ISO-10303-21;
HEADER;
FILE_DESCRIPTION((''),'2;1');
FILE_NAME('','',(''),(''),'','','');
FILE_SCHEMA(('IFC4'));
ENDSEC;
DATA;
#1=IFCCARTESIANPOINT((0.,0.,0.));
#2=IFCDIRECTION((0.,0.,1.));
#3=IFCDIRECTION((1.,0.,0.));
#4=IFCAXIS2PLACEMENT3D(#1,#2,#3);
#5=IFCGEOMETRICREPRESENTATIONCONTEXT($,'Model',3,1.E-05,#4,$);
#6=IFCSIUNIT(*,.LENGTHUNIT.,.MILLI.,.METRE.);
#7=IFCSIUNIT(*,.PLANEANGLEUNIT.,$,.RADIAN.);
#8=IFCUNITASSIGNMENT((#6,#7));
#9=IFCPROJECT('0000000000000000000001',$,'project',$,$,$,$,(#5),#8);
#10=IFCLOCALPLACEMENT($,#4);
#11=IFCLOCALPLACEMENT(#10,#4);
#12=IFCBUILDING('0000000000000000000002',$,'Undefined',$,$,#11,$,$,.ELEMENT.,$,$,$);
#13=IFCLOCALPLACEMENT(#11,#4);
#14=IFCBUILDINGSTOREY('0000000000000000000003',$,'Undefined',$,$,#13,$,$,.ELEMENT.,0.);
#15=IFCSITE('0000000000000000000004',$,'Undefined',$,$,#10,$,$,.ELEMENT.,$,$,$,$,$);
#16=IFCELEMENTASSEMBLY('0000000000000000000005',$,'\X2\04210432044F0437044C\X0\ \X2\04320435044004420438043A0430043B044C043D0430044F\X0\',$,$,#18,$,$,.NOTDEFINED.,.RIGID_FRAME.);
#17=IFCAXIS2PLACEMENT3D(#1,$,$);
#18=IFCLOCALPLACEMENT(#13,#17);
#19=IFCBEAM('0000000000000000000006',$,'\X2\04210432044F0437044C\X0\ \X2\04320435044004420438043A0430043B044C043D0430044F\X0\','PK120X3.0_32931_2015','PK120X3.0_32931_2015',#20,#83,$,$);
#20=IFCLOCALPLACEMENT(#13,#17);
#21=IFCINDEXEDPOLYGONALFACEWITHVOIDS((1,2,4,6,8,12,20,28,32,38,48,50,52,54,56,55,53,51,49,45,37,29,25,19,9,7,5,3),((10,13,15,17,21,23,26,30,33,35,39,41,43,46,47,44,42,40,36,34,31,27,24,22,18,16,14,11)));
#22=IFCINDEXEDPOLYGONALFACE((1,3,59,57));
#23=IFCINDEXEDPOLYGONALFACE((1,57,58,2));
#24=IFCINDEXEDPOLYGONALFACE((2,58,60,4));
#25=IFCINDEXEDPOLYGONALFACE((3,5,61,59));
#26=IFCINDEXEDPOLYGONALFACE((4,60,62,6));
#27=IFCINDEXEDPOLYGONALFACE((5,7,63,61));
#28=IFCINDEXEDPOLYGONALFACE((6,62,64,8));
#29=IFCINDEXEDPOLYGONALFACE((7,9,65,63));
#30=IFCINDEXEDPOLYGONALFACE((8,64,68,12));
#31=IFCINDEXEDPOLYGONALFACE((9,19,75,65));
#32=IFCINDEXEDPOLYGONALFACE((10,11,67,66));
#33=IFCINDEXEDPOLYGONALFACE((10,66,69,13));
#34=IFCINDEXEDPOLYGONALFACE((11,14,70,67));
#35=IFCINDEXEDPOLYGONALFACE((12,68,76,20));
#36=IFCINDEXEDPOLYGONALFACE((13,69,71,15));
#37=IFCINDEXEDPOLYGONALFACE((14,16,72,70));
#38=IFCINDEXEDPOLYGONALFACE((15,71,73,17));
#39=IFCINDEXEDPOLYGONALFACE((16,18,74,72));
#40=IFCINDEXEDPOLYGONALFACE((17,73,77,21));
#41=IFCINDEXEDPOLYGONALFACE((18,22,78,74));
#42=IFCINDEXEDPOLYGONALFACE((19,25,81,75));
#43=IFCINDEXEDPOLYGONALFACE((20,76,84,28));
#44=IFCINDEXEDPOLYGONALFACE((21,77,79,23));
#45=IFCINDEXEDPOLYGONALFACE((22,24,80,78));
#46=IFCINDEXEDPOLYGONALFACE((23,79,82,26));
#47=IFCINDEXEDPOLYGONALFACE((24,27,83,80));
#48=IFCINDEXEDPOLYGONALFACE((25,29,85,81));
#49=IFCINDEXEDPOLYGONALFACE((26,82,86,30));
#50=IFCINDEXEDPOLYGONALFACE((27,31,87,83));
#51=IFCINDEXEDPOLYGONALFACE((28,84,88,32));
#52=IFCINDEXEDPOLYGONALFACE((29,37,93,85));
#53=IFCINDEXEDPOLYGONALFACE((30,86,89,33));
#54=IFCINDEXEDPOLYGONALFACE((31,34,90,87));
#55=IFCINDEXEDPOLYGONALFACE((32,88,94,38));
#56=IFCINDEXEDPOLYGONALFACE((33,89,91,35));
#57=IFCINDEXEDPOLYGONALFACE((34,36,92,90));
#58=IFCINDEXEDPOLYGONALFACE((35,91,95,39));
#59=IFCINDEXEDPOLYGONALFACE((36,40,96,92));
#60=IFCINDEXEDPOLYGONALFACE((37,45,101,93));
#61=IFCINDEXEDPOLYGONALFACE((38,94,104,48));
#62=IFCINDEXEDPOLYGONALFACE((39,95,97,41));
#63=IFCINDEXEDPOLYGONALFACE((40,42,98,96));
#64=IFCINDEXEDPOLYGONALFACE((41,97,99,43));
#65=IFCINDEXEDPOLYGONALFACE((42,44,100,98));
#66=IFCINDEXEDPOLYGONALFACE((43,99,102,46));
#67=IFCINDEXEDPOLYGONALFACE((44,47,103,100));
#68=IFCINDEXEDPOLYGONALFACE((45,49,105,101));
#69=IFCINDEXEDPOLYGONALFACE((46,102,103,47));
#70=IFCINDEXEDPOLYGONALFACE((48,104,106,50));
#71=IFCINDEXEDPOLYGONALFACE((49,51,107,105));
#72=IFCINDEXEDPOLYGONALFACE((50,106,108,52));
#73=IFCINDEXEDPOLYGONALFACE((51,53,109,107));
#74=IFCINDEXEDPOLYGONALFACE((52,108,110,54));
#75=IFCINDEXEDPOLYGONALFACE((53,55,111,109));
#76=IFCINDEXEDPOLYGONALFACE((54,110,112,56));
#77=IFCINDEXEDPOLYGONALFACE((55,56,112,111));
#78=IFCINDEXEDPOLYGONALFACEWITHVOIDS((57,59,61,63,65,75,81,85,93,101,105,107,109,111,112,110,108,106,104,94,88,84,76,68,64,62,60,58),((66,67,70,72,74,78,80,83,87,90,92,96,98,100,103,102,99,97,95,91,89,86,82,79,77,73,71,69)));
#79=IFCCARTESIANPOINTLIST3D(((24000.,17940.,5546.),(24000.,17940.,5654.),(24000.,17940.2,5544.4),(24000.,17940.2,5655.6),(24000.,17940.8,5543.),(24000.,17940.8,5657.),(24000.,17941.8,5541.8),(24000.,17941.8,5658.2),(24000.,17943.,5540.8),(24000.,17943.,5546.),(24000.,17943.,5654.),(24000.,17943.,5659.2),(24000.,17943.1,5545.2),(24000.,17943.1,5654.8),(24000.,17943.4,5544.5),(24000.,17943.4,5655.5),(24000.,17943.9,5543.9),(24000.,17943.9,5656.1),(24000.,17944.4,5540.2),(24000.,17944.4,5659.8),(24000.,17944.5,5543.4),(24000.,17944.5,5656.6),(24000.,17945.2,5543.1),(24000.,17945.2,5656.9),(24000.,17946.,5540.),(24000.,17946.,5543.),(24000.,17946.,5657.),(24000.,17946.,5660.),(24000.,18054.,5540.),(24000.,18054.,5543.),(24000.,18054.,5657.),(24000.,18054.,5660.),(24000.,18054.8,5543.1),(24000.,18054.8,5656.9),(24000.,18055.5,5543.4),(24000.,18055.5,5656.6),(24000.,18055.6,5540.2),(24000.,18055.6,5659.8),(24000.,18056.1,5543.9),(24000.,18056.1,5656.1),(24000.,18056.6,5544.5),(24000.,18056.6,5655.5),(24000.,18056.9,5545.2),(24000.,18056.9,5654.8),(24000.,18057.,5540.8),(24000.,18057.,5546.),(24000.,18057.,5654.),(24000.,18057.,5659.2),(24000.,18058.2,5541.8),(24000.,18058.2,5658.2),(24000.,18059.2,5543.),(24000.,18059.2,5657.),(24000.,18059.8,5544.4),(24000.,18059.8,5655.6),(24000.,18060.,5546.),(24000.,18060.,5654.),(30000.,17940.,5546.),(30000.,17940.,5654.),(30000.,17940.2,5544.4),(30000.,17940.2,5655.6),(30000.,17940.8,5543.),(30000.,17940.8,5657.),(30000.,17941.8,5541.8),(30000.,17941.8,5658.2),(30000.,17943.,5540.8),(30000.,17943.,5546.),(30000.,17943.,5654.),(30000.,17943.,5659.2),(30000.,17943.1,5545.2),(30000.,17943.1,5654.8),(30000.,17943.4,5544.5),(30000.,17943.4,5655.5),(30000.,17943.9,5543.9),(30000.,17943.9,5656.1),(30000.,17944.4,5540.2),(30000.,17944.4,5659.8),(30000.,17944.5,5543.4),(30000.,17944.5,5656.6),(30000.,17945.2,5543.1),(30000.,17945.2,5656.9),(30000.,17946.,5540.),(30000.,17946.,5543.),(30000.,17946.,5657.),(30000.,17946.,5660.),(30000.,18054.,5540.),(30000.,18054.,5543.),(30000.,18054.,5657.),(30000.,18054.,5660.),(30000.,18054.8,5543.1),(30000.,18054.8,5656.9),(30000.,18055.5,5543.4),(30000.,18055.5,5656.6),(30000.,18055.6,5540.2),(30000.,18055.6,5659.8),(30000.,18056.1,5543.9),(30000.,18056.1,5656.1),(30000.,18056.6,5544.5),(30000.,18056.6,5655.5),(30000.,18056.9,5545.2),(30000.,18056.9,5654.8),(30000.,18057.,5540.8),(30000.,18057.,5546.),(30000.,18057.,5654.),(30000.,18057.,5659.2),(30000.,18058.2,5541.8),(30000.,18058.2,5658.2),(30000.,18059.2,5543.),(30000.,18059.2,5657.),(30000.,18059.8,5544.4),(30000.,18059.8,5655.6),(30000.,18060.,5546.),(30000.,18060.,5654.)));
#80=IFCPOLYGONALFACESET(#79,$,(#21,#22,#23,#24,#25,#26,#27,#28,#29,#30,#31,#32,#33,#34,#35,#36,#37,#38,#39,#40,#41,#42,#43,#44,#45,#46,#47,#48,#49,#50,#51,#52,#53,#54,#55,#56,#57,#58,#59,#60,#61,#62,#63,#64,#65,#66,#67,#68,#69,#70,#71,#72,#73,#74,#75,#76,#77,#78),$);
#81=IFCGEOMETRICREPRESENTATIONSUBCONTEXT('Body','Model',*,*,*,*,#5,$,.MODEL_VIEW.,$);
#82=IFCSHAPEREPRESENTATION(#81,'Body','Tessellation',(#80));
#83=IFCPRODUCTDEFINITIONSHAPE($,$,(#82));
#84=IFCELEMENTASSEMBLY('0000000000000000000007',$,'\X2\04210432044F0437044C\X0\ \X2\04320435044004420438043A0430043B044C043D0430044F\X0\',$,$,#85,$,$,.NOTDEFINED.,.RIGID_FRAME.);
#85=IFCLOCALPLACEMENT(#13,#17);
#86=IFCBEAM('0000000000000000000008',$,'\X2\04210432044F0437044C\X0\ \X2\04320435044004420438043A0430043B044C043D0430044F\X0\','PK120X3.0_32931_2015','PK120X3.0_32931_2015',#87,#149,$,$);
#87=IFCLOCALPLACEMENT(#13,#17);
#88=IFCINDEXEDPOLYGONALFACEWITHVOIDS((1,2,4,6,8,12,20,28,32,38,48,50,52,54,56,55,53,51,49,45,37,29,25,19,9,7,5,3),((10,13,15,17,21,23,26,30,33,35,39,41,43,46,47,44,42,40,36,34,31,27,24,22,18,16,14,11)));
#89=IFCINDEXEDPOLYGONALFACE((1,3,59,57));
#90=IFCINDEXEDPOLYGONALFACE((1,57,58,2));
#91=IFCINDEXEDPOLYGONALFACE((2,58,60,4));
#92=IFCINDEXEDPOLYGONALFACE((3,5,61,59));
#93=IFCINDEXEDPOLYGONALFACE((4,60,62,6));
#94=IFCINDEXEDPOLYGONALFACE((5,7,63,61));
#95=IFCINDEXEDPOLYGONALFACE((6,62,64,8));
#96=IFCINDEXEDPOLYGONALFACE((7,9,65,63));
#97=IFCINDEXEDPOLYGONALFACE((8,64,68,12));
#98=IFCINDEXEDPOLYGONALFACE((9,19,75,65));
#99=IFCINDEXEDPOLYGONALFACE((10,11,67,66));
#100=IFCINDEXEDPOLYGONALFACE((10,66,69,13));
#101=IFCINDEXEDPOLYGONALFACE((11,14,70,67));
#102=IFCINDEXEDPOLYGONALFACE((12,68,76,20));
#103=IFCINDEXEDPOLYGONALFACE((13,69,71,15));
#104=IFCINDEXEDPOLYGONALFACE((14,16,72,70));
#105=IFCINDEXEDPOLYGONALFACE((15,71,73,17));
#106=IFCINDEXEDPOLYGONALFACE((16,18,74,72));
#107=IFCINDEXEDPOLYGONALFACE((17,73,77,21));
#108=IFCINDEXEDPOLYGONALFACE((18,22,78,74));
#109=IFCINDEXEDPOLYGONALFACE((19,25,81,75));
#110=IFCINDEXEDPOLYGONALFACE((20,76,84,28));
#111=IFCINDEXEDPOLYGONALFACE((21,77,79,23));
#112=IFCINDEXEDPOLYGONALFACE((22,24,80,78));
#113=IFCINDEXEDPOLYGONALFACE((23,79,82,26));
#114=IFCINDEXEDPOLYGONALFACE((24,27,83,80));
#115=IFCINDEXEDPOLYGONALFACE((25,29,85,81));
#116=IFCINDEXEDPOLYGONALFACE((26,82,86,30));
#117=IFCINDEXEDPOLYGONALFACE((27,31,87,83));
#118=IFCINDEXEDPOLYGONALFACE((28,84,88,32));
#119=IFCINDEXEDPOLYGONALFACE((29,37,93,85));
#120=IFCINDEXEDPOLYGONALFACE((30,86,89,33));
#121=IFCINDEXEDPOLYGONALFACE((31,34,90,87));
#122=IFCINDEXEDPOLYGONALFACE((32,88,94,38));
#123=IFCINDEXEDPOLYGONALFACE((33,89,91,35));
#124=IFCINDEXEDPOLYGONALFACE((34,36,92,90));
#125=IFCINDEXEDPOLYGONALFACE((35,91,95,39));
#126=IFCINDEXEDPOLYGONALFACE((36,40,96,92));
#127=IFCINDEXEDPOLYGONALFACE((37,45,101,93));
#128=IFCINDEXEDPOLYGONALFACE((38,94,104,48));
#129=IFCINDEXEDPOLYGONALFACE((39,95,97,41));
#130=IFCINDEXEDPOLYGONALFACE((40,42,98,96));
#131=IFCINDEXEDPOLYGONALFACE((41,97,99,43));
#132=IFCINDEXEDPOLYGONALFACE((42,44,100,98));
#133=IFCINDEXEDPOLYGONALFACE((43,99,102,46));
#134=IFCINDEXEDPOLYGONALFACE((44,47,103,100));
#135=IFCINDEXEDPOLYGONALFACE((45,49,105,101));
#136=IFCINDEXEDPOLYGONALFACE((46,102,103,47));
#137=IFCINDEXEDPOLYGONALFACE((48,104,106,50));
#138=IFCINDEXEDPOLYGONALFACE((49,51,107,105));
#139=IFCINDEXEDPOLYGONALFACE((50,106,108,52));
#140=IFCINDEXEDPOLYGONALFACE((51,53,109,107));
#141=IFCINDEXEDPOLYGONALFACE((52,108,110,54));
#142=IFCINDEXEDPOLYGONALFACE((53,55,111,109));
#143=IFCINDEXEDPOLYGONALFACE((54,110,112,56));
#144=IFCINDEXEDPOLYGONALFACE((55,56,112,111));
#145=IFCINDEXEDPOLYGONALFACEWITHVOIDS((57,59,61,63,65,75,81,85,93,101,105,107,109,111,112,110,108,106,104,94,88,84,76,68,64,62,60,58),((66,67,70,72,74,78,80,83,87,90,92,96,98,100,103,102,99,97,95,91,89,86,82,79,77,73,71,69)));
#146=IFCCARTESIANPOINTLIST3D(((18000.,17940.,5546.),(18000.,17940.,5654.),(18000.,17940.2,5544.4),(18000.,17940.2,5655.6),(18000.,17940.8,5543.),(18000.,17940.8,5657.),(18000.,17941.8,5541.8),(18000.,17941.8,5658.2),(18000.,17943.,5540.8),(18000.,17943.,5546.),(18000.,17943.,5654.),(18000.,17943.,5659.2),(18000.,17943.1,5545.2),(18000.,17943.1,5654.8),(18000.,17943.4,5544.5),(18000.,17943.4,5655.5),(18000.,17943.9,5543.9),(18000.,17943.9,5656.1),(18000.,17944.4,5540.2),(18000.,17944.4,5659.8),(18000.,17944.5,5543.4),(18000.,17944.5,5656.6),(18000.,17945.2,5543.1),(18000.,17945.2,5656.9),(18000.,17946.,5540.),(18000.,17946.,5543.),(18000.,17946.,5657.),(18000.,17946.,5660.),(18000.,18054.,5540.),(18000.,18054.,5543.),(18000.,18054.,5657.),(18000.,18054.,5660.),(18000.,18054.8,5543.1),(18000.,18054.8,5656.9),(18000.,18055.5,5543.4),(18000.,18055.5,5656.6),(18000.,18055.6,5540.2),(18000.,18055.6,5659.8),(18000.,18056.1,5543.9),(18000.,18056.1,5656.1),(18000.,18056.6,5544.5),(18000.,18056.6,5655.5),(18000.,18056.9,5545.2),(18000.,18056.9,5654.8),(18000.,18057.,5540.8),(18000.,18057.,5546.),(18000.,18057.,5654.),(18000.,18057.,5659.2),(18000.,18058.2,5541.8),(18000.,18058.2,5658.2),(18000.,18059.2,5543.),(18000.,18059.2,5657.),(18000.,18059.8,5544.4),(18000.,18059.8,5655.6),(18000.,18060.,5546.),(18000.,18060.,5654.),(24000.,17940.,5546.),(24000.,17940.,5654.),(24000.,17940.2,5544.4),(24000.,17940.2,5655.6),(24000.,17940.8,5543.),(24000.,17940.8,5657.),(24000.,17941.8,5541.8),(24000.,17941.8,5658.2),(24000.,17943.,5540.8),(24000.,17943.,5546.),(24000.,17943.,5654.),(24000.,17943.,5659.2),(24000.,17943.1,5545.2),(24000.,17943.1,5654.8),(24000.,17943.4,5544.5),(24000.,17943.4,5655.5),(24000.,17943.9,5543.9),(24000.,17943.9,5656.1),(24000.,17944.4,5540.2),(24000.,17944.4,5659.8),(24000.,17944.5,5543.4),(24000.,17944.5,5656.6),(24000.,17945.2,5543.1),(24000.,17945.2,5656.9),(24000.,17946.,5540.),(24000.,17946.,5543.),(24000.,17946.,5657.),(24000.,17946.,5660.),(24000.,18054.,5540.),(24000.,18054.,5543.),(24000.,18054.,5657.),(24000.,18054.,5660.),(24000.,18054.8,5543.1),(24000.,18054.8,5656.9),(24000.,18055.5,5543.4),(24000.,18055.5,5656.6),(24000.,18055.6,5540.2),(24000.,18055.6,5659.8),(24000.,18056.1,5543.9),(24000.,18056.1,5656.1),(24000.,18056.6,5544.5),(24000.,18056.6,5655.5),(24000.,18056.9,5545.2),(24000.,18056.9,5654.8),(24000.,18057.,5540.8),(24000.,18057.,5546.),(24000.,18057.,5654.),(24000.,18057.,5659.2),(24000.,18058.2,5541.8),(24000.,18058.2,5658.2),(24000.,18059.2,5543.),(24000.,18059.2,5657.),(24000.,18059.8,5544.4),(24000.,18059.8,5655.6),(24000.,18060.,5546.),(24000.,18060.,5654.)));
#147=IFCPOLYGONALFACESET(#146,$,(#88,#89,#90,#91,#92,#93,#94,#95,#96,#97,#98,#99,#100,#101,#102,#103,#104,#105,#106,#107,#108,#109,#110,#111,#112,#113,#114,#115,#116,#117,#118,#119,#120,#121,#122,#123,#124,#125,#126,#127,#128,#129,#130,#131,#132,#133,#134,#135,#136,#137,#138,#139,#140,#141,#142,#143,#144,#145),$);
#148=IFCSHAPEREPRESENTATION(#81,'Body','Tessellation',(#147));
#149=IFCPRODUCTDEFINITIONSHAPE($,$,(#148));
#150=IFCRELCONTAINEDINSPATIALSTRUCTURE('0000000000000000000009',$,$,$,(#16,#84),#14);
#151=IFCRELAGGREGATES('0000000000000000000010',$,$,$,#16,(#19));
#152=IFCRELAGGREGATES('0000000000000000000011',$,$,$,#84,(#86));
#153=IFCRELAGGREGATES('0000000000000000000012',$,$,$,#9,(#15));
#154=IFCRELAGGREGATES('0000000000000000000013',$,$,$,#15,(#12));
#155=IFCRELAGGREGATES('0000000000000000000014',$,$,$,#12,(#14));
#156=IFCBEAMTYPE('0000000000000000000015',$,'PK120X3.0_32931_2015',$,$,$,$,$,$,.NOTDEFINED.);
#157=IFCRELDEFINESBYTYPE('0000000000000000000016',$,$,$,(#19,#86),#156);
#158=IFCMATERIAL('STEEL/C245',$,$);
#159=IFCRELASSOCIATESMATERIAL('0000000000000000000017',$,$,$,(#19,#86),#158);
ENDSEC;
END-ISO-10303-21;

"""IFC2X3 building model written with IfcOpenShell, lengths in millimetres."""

from ifc_helpers import new_model, si_unit, frame, origin_with_axes, origin_2d_with_axis, place, context, subcontext, project, spatial, hollow_rectangle, extrude, material, type_object, element, aggregate, save


model = new_model("IFC2X3")

# Units and contexts
model_context = context("Model", 3, precision=1e-05, world=origin_with_axes())
body_context = subcontext(model_context, "Body", "Model", "MODEL_VIEW")
ifc_project = project(units=[si_unit("LENGTHUNIT", "METRE", prefix="MILLI"), si_unit("PLANEANGLEUNIT", "RADIAN")], contexts=[model_context])

# Site, building, storey
site_placement = place(None, origin_with_axes())
site = spatial("IfcSite", under=ifc_project, at=site_placement, Name="Undefined", CompositionType="ELEMENT")
building_placement = place(site_placement, origin_with_axes())
building = spatial("IfcBuilding", under=site, at=building_placement, Name="Undefined", CompositionType="ELEMENT")
storey_placement = place(building_placement, origin_with_axes())
storey = spatial("IfcBuildingStorey", under=building, at=storey_placement, Name="Undefined", CompositionType="ELEMENT", Elevation=0.0)

# Shared definitions
ifc_material_1 = material(Name="STEEL/C245")

# Element assemblies, beams
beam_type_1 = type_object("IfcBeamType", Name="PK120X3.0_32931_2015", PredefinedType="NOTDEFINED")
assembly_1_placement = place(storey_placement, origin_with_axes())
assembly_1 = element("IfcElementAssembly", 1, at=assembly_1_placement, inside=storey, Name="Связь вертикальная", AssemblyPlace="NOTDEFINED", PredefinedType="RIGID_FRAME")
beam_1_placement = place(assembly_1_placement, frame((24000.0, 18000.0, 5600.0), z_axis=(0.0, 0.0, 1.0), x_axis=(1.0, 0.0, 0.0)))
beam_1 = element("IfcBeam", 2, at=beam_1_placement, type_object=beam_type_1, material=ifc_material_1, Name="Связь вертикальная", Description="PK120X3.0_32931_2015", ObjectType="PK120X3.0_32931_2015", context=body_context, shape_type="SweptSolid", body=[
    extrude(hollow_rectangle(XDim=120.0, YDim=120.0, WallThickness=3.0, InnerFilletRadius=3.0, OuterFilletRadius=6.0, at=origin_2d_with_axis()), frame((6000.0, 0.0, 0.0), z_axis=(-1.0, 0.0, 0.0), x_axis=(0.0, -1.0, 0.0)), (0.0, 0.0, 1.0), 6000.0),
])
aggregate(assembly_1, [beam_1])
assembly_2_placement = place(storey_placement, origin_with_axes())
assembly_2 = element("IfcElementAssembly", 3, at=assembly_2_placement, inside=storey, Name="Связь вертикальная", AssemblyPlace="NOTDEFINED", PredefinedType="RIGID_FRAME")
beam_2_placement = place(assembly_2_placement, frame((18000.0, 18000.0, 5600.0), z_axis=(0.0, 0.0, 1.0), x_axis=(1.0, 0.0, 0.0)))
beam_2 = element("IfcBeam", 4, at=beam_2_placement, type_object=beam_type_1, material=ifc_material_1, Name="Связь вертикальная", Description="PK120X3.0_32931_2015", ObjectType="PK120X3.0_32931_2015", context=body_context, shape_type="SweptSolid", body=[
    extrude(hollow_rectangle(XDim=120.0, YDim=120.0, WallThickness=3.0, InnerFilletRadius=3.0, OuterFilletRadius=6.0, at=origin_2d_with_axis()), frame((6000.0, 0.0, 0.0), z_axis=(-1.0, 0.0, 0.0), x_axis=(0.0, -1.0, 0.0)), (0.0, 0.0, 1.0), 6000.0),
])
aggregate(assembly_2, [beam_2])

save(model, "model.ifc")
